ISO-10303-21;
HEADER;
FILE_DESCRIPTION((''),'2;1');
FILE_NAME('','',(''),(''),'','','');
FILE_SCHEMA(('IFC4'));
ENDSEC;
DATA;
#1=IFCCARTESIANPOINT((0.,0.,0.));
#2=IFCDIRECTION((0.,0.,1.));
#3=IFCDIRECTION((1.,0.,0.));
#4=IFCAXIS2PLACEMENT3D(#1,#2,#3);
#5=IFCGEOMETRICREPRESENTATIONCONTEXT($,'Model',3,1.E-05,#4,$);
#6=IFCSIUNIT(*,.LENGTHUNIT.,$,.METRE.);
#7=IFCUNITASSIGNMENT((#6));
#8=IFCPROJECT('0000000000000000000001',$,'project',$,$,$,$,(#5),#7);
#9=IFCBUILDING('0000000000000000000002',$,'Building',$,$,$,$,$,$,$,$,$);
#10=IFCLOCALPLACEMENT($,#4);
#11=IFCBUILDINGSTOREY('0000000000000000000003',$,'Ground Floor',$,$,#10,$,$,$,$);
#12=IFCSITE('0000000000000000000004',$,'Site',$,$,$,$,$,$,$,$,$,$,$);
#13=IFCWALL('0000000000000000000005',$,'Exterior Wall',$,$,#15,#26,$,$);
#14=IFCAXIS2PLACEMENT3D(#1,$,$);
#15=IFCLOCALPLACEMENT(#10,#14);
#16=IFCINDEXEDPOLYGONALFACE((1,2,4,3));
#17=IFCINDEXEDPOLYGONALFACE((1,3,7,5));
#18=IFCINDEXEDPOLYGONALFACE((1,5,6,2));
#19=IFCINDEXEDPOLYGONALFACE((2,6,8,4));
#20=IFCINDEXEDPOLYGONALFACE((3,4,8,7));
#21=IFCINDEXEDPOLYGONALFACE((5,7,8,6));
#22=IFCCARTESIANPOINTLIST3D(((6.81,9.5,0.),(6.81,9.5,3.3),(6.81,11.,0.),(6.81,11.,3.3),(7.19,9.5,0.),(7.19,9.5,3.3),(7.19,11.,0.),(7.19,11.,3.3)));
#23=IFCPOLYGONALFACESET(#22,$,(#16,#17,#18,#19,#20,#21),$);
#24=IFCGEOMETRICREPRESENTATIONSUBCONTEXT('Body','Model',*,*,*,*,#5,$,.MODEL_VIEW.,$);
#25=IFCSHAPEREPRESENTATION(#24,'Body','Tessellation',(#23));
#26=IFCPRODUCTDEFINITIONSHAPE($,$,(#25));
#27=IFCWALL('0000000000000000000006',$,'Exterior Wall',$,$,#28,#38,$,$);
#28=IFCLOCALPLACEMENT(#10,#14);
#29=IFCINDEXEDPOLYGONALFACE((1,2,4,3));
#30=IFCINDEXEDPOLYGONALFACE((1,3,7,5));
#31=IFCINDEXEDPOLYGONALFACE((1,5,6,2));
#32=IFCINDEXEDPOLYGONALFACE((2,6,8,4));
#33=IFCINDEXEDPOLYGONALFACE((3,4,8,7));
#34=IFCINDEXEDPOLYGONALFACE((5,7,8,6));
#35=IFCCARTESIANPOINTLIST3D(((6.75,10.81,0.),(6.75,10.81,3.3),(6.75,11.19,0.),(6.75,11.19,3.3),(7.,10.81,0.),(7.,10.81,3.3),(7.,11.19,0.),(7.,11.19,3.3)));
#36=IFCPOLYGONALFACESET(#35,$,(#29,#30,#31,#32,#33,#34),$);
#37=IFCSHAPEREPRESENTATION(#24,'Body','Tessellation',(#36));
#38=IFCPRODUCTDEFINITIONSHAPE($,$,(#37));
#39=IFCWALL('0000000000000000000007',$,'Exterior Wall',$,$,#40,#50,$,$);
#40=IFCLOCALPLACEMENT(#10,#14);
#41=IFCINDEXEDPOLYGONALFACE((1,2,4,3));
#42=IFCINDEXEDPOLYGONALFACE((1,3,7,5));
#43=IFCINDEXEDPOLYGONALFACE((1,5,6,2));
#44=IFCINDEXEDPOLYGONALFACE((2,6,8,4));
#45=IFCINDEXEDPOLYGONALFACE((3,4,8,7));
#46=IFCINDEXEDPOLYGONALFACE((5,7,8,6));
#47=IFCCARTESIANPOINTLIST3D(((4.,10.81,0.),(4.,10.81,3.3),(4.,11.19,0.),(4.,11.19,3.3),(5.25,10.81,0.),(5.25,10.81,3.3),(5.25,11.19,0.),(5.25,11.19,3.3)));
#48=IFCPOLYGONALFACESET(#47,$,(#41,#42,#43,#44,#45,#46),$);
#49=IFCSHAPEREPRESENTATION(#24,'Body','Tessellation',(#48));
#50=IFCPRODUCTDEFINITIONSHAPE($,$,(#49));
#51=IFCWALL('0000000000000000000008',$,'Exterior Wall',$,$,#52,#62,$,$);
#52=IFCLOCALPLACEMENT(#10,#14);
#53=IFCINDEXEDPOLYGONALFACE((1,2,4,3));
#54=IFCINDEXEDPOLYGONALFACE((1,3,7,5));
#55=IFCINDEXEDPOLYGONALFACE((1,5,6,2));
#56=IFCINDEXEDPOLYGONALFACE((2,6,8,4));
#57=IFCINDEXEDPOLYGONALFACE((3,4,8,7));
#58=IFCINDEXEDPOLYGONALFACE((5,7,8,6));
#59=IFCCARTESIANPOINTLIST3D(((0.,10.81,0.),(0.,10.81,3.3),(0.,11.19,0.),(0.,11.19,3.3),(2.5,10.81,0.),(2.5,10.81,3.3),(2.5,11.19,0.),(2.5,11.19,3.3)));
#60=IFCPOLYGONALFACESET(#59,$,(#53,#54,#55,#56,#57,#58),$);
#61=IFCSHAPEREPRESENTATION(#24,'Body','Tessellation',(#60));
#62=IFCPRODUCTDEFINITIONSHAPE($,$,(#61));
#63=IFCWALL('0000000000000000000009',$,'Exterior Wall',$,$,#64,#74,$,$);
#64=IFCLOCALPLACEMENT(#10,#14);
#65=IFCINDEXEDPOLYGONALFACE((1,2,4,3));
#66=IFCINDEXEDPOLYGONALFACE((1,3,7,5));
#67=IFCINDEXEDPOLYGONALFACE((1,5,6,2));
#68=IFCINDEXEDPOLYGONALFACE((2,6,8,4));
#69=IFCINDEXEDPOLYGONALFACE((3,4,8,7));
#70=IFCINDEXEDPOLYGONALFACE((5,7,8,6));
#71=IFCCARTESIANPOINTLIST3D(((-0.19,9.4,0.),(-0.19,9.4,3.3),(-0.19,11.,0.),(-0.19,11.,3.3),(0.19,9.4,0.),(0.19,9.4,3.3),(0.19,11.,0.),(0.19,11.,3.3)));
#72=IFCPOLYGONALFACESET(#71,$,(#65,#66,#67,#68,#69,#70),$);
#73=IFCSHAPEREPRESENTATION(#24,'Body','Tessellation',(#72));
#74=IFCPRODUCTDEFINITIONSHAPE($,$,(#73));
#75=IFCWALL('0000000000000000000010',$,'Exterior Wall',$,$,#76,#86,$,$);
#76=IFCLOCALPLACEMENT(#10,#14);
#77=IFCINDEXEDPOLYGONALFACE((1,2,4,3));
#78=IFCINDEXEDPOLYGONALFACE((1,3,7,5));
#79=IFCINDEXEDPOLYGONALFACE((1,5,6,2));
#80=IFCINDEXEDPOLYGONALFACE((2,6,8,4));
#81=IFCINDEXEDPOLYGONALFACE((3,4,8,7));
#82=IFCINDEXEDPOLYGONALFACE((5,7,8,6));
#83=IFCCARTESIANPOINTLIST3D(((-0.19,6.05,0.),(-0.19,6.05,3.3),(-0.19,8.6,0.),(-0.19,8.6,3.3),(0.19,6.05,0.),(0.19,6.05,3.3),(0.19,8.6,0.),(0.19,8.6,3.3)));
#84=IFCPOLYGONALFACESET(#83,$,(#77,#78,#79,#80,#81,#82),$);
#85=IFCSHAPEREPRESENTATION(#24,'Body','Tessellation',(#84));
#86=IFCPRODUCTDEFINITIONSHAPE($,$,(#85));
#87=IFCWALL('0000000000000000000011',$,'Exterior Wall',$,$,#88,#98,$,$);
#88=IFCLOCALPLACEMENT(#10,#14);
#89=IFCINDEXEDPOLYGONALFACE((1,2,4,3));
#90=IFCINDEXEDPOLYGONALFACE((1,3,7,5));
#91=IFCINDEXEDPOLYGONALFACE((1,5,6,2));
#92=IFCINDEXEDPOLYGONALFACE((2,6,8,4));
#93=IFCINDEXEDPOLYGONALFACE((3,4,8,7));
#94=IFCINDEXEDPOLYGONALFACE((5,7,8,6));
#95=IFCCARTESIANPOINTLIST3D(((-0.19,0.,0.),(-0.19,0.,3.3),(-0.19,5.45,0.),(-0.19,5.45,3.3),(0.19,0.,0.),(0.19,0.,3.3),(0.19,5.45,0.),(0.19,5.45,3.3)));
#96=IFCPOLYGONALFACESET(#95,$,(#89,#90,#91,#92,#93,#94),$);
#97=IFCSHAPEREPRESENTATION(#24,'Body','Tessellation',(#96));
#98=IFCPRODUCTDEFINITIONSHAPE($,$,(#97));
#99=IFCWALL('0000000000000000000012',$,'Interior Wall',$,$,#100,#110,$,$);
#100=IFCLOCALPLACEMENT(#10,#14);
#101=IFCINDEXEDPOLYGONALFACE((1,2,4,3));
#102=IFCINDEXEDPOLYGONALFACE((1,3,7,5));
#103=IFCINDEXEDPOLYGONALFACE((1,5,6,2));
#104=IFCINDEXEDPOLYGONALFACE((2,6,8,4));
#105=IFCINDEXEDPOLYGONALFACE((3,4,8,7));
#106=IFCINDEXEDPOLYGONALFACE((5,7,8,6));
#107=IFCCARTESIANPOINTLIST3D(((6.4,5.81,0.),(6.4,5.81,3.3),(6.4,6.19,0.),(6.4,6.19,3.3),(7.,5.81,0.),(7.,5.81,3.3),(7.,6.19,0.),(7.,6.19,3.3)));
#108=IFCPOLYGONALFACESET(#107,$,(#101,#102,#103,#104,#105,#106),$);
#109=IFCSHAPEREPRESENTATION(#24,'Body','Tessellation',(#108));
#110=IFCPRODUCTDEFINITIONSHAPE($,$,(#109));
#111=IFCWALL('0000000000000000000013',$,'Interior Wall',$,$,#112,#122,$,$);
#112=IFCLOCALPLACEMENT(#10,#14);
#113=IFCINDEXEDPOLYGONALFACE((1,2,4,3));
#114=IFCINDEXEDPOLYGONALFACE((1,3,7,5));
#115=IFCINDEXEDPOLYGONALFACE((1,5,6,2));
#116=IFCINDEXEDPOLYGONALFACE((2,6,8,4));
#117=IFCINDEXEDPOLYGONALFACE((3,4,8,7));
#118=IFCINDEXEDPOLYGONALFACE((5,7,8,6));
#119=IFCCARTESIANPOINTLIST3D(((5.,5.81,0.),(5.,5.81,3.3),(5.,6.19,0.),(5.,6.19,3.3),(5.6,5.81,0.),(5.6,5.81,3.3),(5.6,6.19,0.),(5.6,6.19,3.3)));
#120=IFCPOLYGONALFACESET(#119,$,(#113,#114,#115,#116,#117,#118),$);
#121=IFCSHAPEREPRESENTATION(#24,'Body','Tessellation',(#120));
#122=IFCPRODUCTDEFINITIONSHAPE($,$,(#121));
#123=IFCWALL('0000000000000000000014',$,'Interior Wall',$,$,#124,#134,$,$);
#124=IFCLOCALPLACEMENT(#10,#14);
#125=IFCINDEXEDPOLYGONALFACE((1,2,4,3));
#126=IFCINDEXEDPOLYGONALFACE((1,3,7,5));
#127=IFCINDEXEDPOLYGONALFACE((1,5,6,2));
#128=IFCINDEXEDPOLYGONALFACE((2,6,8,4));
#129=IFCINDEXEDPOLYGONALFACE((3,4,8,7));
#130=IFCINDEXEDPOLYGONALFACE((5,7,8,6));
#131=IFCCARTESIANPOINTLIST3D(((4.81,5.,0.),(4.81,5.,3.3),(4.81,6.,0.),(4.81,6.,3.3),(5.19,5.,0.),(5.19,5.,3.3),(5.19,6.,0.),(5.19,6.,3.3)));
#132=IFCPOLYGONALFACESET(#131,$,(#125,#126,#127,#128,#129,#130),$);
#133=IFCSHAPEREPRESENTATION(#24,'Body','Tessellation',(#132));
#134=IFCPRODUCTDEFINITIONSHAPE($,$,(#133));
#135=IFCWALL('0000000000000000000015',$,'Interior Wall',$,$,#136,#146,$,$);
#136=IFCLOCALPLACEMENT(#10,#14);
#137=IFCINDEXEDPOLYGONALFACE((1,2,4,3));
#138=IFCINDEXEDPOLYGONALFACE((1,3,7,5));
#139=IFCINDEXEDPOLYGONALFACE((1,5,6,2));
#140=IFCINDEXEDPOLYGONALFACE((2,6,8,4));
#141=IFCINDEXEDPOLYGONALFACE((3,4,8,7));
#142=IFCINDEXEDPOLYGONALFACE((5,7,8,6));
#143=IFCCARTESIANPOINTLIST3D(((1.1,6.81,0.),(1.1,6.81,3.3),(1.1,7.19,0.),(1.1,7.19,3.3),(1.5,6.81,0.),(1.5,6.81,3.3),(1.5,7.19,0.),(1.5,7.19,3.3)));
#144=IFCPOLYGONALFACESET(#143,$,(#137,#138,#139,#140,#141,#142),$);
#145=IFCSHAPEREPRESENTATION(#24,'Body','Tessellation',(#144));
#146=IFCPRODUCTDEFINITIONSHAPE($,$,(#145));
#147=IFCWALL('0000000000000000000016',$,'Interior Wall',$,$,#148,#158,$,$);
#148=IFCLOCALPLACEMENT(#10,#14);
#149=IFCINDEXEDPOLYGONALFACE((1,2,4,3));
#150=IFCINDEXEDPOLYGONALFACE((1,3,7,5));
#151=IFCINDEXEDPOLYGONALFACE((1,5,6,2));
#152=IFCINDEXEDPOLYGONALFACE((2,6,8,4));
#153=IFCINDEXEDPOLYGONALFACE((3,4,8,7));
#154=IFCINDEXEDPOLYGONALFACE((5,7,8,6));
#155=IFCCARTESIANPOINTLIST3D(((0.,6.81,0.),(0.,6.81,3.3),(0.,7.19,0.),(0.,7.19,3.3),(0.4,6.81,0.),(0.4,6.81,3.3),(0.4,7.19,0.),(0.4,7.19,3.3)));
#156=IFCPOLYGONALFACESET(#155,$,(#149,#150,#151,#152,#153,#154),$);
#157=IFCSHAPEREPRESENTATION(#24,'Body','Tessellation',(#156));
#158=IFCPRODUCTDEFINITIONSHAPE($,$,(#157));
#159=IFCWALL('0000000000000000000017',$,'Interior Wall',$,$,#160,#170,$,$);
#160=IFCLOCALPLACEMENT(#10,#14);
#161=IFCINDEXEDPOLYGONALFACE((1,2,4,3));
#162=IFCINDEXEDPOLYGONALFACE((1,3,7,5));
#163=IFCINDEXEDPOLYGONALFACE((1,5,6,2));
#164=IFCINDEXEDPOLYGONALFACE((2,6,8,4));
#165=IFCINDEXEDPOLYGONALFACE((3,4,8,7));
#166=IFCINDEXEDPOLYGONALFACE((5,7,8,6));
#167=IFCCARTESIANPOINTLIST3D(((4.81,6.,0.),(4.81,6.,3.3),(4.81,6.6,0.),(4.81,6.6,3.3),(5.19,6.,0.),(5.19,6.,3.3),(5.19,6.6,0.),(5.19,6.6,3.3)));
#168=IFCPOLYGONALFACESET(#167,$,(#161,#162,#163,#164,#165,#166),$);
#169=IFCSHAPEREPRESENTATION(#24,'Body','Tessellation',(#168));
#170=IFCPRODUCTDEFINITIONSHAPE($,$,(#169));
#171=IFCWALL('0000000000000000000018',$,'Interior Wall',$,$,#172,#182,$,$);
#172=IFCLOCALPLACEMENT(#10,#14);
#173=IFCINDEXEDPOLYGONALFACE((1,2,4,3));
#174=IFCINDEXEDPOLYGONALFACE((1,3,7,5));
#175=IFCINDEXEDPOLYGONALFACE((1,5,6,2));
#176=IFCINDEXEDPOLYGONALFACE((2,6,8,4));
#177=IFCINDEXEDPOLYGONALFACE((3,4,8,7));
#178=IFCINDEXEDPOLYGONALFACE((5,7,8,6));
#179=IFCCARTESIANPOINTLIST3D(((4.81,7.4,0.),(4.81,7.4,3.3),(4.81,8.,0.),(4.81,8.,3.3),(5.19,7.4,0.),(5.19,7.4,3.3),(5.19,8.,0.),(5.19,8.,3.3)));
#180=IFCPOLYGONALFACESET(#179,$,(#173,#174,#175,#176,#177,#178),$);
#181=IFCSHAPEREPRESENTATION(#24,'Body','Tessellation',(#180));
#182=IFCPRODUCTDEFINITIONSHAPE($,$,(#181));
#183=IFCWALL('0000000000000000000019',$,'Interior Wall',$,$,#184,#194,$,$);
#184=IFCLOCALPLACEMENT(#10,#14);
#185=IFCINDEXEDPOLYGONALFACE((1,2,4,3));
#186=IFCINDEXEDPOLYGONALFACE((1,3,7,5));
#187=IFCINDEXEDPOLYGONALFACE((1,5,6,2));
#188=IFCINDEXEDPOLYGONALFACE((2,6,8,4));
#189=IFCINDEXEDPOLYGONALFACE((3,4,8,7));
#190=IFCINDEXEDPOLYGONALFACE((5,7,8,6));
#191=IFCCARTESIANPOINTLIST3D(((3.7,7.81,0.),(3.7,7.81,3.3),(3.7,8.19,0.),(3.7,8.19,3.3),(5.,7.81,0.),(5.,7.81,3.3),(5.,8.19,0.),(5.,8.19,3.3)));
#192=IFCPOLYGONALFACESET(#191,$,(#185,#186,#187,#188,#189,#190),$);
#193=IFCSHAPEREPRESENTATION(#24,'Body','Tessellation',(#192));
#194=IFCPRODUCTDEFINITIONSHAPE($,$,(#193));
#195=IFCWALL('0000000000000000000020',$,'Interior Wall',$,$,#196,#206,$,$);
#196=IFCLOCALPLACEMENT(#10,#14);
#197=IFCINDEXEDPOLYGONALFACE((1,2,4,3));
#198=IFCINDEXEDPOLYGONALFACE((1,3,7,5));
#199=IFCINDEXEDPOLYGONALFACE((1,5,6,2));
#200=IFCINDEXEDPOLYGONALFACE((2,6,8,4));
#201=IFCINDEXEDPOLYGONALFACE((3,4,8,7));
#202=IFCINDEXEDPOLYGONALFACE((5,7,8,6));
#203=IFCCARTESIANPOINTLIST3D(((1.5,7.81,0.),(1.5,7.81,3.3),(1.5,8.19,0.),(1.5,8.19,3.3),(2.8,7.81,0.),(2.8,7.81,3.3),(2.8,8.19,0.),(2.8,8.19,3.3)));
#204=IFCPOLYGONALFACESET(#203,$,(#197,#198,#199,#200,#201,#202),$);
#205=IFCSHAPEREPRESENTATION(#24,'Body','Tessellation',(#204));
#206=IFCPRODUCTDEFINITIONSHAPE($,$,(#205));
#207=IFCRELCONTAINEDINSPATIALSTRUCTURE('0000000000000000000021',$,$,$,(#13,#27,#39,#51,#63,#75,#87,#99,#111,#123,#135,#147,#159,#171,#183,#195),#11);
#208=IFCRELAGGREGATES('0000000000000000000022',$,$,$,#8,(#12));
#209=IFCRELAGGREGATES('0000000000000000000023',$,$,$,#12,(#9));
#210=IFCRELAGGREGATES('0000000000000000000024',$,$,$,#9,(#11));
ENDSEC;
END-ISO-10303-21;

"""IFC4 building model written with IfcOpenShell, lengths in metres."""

from ifc_helpers import new_model, si_unit, frame, origin_with_axes, place, context, subcontext, project, spatial, indexed_curve, outline, extrude, element, save


model = new_model("IFC4")

# Units and contexts
model_context = context("Model", 3, precision=1e-05, world=origin_with_axes())
body_context = subcontext(model_context, "Body", "Model", "MODEL_VIEW")
ifc_project = project(units=[si_unit("LENGTHUNIT", "METRE")], contexts=[model_context])

# Site, building, storey
site = spatial("IfcSite", under=ifc_project, Name="Site")
building = spatial("IfcBuilding", under=site, Name="Building")
storey_placement = place(None, origin_with_axes())
storey = spatial("IfcBuildingStorey", under=building, at=storey_placement, Name="Ground Floor")

# Walls
wall_1_placement = place(storey_placement, frame((7.0, 9.5, 0.0), z_axis=(0.0, 0.0, 1.0), x_axis=(0.0, 1.0, 0.0)))
element("IfcWall", 1, at=wall_1_placement, inside=storey, Name="Exterior Wall", context=body_context, shape_type="SweptSolid", body=[
    extrude(outline(indexed_curve([(0.0, 0.0), (0.0, 0.38), (1.5, 0.38), (1.5, 0.0), (0.0, 0.0)], self_intersect=False)), frame((0.0, -0.19, 0.0), z_axis=(0.0, 0.0, 1.0), x_axis=(1.0, 0.0, 0.0)), (0.0, 0.0, 1.0), 3.3),
])
wall_2_placement = place(storey_placement, frame((7.0, 11.0, 0.0), z_axis=(0.0, 0.0, 1.0), x_axis=(-1.0, 0.0, 0.0)))
element("IfcWall", 2, at=wall_2_placement, inside=storey, Name="Exterior Wall", context=body_context, shape_type="SweptSolid", body=[
    extrude(outline(indexed_curve([(0.0, 0.0), (0.0, 0.38), (0.25, 0.38), (0.25, 0.0), (0.0, 0.0)], self_intersect=False)), frame((0.0, -0.19, 0.0), z_axis=(0.0, 0.0, 1.0), x_axis=(1.0, 0.0, 0.0)), (0.0, 0.0, 1.0), 3.3),
])
wall_3_placement = place(storey_placement, frame((5.25, 11.0, 0.0), z_axis=(0.0, 0.0, 1.0), x_axis=(-1.0, 0.0, 0.0)))
element("IfcWall", 3, at=wall_3_placement, inside=storey, Name="Exterior Wall", context=body_context, shape_type="SweptSolid", body=[
    extrude(outline(indexed_curve([(0.0, 0.0), (0.0, 0.38), (1.25, 0.38), (1.25, 0.0), (0.0, 0.0)], self_intersect=False)), frame((0.0, -0.19, 0.0), z_axis=(0.0, 0.0, 1.0), x_axis=(1.0, 0.0, 0.0)), (0.0, 0.0, 1.0), 3.3),
])
wall_4_placement = place(storey_placement, frame((2.5, 11.0, 0.0), z_axis=(0.0, 0.0, 1.0), x_axis=(-1.0, 0.0, 0.0)))
element("IfcWall", 4, at=wall_4_placement, inside=storey, Name="Exterior Wall", context=body_context, shape_type="SweptSolid", body=[
    extrude(outline(indexed_curve([(0.0, 0.0), (0.0, 0.38), (2.5, 0.38), (2.5, 0.0), (0.0, 0.0)], self_intersect=False)), frame((0.0, -0.19, 0.0), z_axis=(0.0, 0.0, 1.0), x_axis=(1.0, 0.0, 0.0)), (0.0, 0.0, 1.0), 3.3),
])
wall_5_placement = place(storey_placement, frame((0.0, 11.0, 0.0), z_axis=(0.0, 0.0, 1.0), x_axis=(0.0, -1.0, 0.0)))
element("IfcWall", 5, at=wall_5_placement, inside=storey, Name="Exterior Wall", context=body_context, shape_type="SweptSolid", body=[
    extrude(outline(indexed_curve([(0.0, 0.0), (0.0, 0.38), (1.6, 0.38), (1.6, 0.0), (0.0, 0.0)], self_intersect=False)), frame((0.0, -0.19, 0.0), z_axis=(0.0, 0.0, 1.0), x_axis=(1.0, 0.0, 0.0)), (0.0, 0.0, 1.0), 3.3),
])
wall_6_placement = place(storey_placement, frame((0.0, 8.6, 0.0), z_axis=(0.0, 0.0, 1.0), x_axis=(0.0, -1.0, 0.0)))
element("IfcWall", 6, at=wall_6_placement, inside=storey, Name="Exterior Wall", context=body_context, shape_type="SweptSolid", body=[
    extrude(outline(indexed_curve([(0.0, 0.0), (0.0, 0.38), (2.55, 0.38), (2.55, 0.0), (0.0, 0.0)], self_intersect=False)), frame((0.0, -0.19, 0.0), z_axis=(0.0, 0.0, 1.0), x_axis=(1.0, 0.0, 0.0)), (0.0, 0.0, 1.0), 3.3),
])
wall_7_placement = place(storey_placement, frame((0.0, 5.45, 0.0), z_axis=(0.0, 0.0, 1.0), x_axis=(0.0, -1.0, 0.0)))
element("IfcWall", 7, at=wall_7_placement, inside=storey, Name="Exterior Wall", context=body_context, shape_type="SweptSolid", body=[
    extrude(outline(indexed_curve([(0.0, 0.0), (0.0, 0.38), (5.45, 0.38), (5.45, 0.0), (0.0, 0.0)], self_intersect=False)), frame((0.0, -0.19, 0.0), z_axis=(0.0, 0.0, 1.0), x_axis=(1.0, 0.0, 0.0)), (0.0, 0.0, 1.0), 3.3),
])
for number, where, z_axis, x_axis, name in (
    (8, (7.0, 6.0, 0.0), (0.0, 0.0, 1.0), (-1.0, 0.0, 0.0), "Interior Wall"),
    (9, (5.6, 6.0, 0.0), (0.0, 0.0, 1.0), (-1.0, 0.0, 0.0), "Interior Wall"),
):
    element("IfcWall", number, at=place(storey_placement, frame(where, z_axis=z_axis, x_axis=x_axis)), inside=storey, Name=name, context=body_context, shape_type="SweptSolid", body=[
        extrude(outline(indexed_curve([(0.0, 0.0), (0.0, 0.38), (0.6, 0.38), (0.6, 0.0), (0.0, 0.0)], self_intersect=False)), frame((0.0, -0.19, 0.0), z_axis=(0.0, 0.0, 1.0), x_axis=(1.0, 0.0, 0.0)), (0.0, 0.0, 1.0), 3.3),
    ])
wall_8_placement = place(storey_placement, frame((5.0, 6.0, 0.0), z_axis=(0.0, 0.0, 1.0), x_axis=(0.0, -1.0, 0.0)))
element("IfcWall", 10, at=wall_8_placement, inside=storey, Name="Interior Wall", context=body_context, shape_type="SweptSolid", body=[
    extrude(outline(indexed_curve([(0.0, 0.0), (0.0, 0.38), (1.0, 0.38), (1.0, 0.0), (0.0, 0.0)], self_intersect=False)), frame((0.0, -0.19, 0.0), z_axis=(0.0, 0.0, 1.0), x_axis=(1.0, 0.0, 0.0)), (0.0, 0.0, 1.0), 3.3),
])
for number, where, z_axis, x_axis, name in (
    (11, (1.5, 7.0, 0.0), (0.0, 0.0, 1.0), (-1.0, 0.0, 0.0), "Interior Wall"),
    (12, (0.4, 7.0, 0.0), (0.0, 0.0, 1.0), (-1.0, 0.0, 0.0), "Interior Wall"),
):
    element("IfcWall", number, at=place(storey_placement, frame(where, z_axis=z_axis, x_axis=x_axis)), inside=storey, Name=name, context=body_context, shape_type="SweptSolid", body=[
        extrude(outline(indexed_curve([(0.0, 0.0), (0.0, 0.38), (0.4, 0.38), (0.4, 0.0), (0.0, 0.0)], self_intersect=False)), frame((0.0, -0.19, 0.0), z_axis=(0.0, 0.0, 1.0), x_axis=(1.0, 0.0, 0.0)), (0.0, 0.0, 1.0), 3.3),
    ])
for number, where, z_axis, x_axis, name in (
    (13, (5.0, 6.0, 0.0), (0.0, 0.0, 1.0), (0.0, 1.0, 0.0), "Interior Wall"),
    (14, (5.0, 7.4, 0.0), (0.0, 0.0, 1.0), (0.0, 1.0, 0.0), "Interior Wall"),
):
    element("IfcWall", number, at=place(storey_placement, frame(where, z_axis=z_axis, x_axis=x_axis)), inside=storey, Name=name, context=body_context, shape_type="SweptSolid", body=[
        extrude(outline(indexed_curve([(0.0, 0.0), (0.0, 0.38), (0.6, 0.38), (0.6, 0.0), (0.0, 0.0)], self_intersect=False)), frame((0.0, -0.19, 0.0), z_axis=(0.0, 0.0, 1.0), x_axis=(1.0, 0.0, 0.0)), (0.0, 0.0, 1.0), 3.3),
    ])
for number, where, z_axis, x_axis, name in (
    (15, (5.0, 8.0, 0.0), (0.0, 0.0, 1.0), (-1.0, 0.0, 0.0), "Interior Wall"),
    (16, (2.8, 8.0, 0.0), (0.0, 0.0, 1.0), (-1.0, 0.0, 0.0), "Interior Wall"),
):
    element("IfcWall", number, at=place(storey_placement, frame(where, z_axis=z_axis, x_axis=x_axis)), inside=storey, Name=name, context=body_context, shape_type="SweptSolid", body=[
        extrude(outline(indexed_curve([(0.0, 0.0), (0.0, 0.38), (1.3, 0.38), (1.3, 0.0), (0.0, 0.0)], self_intersect=False)), frame((0.0, -0.19, 0.0), z_axis=(0.0, 0.0, 1.0), x_axis=(1.0, 0.0, 0.0)), (0.0, 0.0, 1.0), 3.3),
    ])

save(model, "model.ifc")
